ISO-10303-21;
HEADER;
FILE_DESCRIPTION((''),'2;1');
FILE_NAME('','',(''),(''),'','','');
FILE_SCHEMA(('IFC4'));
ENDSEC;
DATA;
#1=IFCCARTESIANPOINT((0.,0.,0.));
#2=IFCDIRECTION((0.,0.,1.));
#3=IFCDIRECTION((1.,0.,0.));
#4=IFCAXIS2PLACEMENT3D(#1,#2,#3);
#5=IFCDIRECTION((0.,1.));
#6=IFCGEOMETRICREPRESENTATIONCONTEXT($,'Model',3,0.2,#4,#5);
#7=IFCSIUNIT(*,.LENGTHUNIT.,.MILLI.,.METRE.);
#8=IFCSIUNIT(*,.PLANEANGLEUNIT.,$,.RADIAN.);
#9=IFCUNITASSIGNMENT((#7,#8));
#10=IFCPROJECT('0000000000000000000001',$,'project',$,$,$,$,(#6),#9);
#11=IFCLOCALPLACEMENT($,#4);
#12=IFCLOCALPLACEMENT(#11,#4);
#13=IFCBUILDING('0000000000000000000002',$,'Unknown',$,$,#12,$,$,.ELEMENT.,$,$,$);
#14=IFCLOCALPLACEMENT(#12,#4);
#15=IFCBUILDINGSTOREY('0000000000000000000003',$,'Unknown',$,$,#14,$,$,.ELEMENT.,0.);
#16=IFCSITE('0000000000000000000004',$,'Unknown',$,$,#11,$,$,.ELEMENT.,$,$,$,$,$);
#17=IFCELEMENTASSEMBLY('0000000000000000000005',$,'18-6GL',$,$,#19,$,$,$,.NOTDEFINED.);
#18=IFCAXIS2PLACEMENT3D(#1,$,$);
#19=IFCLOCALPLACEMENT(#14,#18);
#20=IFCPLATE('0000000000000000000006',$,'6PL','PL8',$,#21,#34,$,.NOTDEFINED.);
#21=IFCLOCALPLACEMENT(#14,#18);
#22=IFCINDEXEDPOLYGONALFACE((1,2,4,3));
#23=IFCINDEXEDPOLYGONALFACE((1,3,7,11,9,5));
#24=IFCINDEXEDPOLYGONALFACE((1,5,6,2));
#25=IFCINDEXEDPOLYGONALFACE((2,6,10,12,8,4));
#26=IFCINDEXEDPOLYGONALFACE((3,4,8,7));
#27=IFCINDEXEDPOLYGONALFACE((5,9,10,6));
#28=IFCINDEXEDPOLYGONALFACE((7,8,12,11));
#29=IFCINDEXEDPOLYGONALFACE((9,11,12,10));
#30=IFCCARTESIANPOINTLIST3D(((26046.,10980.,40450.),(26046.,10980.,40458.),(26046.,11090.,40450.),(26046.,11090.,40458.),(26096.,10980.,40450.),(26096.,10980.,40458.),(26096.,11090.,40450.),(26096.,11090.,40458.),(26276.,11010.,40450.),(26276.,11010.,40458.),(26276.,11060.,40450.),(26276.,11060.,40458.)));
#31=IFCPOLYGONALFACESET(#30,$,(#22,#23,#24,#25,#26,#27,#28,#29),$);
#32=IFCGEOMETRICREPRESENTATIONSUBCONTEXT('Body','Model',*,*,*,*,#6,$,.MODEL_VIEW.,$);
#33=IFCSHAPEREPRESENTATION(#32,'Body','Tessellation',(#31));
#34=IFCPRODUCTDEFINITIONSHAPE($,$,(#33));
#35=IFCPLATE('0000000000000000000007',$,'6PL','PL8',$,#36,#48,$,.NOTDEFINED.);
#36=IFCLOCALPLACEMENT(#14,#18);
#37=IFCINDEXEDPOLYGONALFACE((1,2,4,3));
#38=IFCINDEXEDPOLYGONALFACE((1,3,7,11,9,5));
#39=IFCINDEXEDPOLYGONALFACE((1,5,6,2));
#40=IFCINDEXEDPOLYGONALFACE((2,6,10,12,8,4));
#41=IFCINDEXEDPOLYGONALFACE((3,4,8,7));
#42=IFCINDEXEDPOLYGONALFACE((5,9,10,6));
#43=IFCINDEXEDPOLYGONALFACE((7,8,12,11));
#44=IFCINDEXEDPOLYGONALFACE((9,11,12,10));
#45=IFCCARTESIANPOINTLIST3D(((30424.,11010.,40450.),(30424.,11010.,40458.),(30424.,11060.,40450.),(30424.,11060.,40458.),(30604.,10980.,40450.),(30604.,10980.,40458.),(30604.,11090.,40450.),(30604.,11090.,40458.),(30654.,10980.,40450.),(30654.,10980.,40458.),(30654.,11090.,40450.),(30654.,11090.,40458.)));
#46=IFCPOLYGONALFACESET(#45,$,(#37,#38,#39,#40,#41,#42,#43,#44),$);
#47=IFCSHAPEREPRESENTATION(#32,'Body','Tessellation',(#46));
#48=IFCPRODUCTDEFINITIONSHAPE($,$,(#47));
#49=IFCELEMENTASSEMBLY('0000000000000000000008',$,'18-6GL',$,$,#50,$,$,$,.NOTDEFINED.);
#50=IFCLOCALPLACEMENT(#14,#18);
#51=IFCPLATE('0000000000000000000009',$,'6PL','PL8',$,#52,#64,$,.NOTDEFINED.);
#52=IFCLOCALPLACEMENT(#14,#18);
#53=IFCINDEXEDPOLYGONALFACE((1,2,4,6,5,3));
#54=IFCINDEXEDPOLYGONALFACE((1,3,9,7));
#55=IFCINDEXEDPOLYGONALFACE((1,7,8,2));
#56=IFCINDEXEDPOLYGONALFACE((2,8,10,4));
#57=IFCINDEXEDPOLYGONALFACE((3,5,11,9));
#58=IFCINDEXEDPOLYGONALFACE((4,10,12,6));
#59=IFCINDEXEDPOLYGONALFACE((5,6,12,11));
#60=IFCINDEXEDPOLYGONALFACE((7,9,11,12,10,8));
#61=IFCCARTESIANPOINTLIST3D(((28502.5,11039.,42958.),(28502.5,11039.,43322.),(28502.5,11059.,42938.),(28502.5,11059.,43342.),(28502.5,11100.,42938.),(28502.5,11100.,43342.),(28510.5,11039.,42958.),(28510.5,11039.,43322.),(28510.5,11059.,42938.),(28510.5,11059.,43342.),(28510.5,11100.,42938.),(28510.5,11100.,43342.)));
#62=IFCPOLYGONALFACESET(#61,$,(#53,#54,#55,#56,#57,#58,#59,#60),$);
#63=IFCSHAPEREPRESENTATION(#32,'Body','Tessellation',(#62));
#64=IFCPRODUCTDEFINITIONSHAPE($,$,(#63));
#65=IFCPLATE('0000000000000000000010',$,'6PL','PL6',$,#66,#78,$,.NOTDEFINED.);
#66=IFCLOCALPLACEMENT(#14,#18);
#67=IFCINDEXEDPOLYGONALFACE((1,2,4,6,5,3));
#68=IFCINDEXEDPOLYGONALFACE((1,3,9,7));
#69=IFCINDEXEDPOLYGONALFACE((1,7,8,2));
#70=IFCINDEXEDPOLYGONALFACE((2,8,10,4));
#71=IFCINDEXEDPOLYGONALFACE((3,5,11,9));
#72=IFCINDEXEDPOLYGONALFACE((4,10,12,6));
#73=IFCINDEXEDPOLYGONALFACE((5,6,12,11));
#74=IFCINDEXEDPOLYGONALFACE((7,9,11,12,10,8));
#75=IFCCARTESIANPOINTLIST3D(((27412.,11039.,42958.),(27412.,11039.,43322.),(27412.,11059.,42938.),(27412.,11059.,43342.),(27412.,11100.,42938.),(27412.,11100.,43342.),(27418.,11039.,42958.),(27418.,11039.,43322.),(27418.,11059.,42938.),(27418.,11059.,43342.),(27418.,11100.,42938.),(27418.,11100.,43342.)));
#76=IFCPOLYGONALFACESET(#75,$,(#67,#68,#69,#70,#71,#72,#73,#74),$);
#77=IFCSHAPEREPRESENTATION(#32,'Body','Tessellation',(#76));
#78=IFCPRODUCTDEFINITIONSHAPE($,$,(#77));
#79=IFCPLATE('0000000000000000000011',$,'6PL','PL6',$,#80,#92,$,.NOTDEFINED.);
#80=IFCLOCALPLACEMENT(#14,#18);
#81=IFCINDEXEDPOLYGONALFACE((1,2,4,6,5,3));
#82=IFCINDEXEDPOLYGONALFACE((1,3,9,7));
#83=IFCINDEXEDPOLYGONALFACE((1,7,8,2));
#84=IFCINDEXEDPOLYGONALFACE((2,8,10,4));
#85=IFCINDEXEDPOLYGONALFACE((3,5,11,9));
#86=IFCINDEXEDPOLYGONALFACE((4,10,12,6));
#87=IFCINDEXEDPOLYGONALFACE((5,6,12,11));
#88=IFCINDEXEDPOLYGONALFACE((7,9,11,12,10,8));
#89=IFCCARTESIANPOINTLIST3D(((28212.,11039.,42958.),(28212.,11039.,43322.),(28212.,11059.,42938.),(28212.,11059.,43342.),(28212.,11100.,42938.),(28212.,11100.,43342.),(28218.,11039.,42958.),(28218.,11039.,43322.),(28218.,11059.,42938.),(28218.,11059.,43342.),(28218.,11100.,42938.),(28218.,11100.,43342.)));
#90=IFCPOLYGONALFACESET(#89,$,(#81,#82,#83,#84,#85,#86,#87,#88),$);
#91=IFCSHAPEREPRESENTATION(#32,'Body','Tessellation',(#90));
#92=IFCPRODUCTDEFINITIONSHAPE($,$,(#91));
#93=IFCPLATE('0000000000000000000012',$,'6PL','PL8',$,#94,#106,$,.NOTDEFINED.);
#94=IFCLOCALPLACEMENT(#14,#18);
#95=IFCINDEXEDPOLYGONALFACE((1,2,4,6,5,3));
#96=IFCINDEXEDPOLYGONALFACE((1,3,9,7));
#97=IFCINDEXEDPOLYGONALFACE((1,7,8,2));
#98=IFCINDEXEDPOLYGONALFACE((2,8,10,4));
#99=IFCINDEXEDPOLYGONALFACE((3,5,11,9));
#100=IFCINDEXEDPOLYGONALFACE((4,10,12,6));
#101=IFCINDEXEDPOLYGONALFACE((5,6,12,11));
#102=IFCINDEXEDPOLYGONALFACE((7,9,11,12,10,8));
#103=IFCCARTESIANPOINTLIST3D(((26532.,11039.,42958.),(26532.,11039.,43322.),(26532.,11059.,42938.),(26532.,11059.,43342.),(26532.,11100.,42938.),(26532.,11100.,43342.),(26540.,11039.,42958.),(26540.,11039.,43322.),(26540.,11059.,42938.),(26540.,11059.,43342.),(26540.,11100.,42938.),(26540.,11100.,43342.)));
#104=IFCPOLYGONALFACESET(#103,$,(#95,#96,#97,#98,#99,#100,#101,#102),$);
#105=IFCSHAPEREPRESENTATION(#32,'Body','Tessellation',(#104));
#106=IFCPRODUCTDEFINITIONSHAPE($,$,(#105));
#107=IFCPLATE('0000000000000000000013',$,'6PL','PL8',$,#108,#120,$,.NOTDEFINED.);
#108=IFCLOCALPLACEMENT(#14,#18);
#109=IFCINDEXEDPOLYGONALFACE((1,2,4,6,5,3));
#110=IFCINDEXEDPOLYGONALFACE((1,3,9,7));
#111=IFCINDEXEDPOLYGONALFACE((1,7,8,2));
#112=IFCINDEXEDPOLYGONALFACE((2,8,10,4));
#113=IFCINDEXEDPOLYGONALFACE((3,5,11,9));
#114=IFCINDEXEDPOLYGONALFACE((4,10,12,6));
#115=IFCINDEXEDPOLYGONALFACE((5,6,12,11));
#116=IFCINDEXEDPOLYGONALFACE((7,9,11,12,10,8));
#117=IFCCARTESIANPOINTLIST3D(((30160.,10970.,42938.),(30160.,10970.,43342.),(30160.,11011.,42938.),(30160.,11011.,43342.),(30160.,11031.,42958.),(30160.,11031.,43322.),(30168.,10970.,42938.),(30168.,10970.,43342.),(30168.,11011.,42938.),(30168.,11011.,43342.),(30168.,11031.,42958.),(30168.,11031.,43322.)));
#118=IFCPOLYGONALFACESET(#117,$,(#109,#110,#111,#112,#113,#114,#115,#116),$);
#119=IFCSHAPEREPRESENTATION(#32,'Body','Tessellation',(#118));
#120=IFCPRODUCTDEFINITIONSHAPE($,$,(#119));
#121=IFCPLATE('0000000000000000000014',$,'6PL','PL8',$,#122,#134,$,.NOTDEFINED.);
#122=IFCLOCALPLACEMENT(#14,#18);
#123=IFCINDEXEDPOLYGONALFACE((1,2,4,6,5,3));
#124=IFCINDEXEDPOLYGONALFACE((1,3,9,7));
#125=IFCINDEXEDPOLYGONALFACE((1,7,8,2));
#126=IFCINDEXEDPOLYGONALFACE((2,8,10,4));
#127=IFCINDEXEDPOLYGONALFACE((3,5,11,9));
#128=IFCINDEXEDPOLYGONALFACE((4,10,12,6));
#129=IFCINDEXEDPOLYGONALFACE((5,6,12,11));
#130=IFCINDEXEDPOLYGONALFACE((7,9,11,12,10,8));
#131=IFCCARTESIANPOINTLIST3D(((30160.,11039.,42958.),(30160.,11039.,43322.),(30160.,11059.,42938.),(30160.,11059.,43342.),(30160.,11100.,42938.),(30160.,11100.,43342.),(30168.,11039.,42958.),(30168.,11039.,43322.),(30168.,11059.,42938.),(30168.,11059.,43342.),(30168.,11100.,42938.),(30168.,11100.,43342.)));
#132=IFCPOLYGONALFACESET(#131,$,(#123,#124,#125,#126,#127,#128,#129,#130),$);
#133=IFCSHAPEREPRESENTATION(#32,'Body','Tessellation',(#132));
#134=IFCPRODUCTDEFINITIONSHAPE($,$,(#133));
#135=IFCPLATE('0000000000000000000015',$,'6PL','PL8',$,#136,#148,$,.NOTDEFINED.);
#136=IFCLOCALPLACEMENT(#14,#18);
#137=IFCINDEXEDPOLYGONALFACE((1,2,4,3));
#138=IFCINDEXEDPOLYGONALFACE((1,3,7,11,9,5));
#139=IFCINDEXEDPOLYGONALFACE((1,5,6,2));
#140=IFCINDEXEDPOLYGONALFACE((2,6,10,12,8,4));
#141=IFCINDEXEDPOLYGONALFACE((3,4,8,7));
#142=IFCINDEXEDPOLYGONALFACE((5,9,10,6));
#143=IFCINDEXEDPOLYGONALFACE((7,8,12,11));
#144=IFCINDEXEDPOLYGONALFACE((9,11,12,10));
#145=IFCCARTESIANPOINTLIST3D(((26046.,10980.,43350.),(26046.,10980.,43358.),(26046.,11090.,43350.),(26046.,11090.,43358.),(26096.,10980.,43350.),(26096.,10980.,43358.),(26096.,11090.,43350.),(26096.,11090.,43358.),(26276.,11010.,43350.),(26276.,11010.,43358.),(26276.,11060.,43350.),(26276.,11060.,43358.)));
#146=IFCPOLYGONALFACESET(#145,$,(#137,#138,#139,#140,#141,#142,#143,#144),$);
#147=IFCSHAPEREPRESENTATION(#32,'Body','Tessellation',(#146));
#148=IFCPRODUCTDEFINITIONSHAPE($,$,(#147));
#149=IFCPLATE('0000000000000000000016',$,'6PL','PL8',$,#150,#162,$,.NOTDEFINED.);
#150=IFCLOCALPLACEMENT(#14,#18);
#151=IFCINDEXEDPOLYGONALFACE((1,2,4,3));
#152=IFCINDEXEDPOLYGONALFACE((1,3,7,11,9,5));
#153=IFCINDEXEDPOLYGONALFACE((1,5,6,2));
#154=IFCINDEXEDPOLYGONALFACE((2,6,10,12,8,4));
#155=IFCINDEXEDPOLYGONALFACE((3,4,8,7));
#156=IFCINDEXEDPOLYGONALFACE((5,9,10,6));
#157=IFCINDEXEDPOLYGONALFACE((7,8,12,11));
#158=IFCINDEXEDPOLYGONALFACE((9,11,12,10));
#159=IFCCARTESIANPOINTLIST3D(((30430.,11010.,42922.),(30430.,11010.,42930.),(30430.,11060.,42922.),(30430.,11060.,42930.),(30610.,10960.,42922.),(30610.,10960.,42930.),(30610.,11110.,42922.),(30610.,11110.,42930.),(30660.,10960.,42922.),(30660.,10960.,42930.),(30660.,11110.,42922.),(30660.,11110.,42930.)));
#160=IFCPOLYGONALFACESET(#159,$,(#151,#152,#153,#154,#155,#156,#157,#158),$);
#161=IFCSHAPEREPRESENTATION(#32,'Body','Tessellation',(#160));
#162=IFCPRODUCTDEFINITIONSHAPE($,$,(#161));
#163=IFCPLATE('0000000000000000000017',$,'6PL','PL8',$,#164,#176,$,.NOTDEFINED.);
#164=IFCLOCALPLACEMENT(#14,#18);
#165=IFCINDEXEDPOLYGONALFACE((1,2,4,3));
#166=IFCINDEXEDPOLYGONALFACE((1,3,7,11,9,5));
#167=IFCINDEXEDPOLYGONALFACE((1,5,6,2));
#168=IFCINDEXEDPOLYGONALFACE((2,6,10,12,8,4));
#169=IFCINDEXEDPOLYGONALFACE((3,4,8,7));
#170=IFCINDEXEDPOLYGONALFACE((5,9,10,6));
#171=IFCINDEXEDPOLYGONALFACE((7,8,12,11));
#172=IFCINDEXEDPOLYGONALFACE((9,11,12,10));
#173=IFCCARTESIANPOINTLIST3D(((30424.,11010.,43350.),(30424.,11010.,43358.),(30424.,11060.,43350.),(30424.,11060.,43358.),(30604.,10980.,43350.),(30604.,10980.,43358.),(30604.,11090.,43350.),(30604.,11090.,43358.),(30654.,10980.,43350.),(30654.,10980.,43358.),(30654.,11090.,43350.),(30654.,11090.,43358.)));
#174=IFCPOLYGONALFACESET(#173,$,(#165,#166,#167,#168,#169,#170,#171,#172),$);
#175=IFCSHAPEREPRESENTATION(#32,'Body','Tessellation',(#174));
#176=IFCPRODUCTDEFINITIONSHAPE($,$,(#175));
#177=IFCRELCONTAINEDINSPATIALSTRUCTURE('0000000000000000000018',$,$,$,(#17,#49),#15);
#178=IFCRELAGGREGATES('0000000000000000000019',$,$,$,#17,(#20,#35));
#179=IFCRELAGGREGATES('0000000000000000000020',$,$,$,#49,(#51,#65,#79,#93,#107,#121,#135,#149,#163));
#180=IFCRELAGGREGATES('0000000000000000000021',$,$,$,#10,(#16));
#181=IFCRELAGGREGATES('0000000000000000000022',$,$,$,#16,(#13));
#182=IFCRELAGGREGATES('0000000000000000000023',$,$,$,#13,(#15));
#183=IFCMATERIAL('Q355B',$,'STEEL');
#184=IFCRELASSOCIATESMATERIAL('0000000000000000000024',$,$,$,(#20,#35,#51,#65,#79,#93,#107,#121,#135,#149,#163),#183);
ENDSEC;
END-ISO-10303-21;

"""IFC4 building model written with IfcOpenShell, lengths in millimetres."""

from ifc_helpers import new_model, si_unit, direction, frame, origin_with_axes, place, context, subcontext, project, spatial, line, indexed_curve, outline, extrude, material, element, aggregate, save


model = new_model("IFC4")

# Units and contexts
model_context = context("Model", 3, precision=0.2, world=origin_with_axes(), true_north=direction((0.0, 1.0)))
body_context = subcontext(model_context, "Body", "Model", "MODEL_VIEW")
ifc_project = project(units=[si_unit("LENGTHUNIT", "METRE", prefix="MILLI"), si_unit("PLANEANGLEUNIT", "RADIAN")], contexts=[model_context])

# Site, building, storey
site_placement = place(None, origin_with_axes())
site = spatial("IfcSite", under=ifc_project, at=site_placement, Name="Unknown", CompositionType="ELEMENT")
building_placement = place(site_placement, origin_with_axes())
building = spatial("IfcBuilding", under=site, at=building_placement, Name="Unknown", CompositionType="ELEMENT")
storey_placement = place(building_placement, origin_with_axes())
storey = spatial("IfcBuildingStorey", under=building, at=storey_placement, Name="Unknown", CompositionType="ELEMENT", Elevation=0.0)

# Shared definitions
ifc_material = material(Name="Q355B", Category="STEEL")

# Element assemblies, plates
assembly_1_placement = place(storey_placement, frame((26000.0, 11035.0, 40240.0), z_axis=(0.0, -1.0, 0.0), x_axis=(1.0, 0.0, 0.0)))
assembly_1 = element("IfcElementAssembly", 1, at=assembly_1_placement, inside=storey, Name="18-6GL", PredefinedType="NOTDEFINED")
plate_1_placement = place(assembly_1_placement, frame((96.0, 214.0, -55.0), z_axis=(0.0, 1.0, 0.0), x_axis=(-1.0, 0.0, 0.0)))
plate_1 = element("IfcPlate", 2, at=plate_1_placement, material=ifc_material, Name="6PL", Description="PL8", PredefinedType="NOTDEFINED", context=body_context, shape_type="SolidModel", body=[
    extrude(outline(indexed_curve([(0.0, 0.0), (50.0, 0.0), (50.0, 110.0), (0.0, 110.0), (-180.0, 80.0), (-180.0, 30.0)], segments=[line(1, 2, 3, 4, 5, 6, 1)])), frame((0.0, 0.0, 4.0), z_axis=(0.0, 0.0, 1.0), x_axis=(1.0, 0.0, 0.0)), (0.0, 0.0, -1.0), 8.0),
])
plate_2_placement = place(assembly_1_placement, frame((4604.0, 214.0, 55.0), z_axis=(0.0, 1.0, 0.0), x_axis=(1.0, 0.0, 0.0)))
plate_2 = element("IfcPlate", 3, at=plate_2_placement, material=ifc_material, Name="6PL", Description="PL8", PredefinedType="NOTDEFINED", context=body_context, shape_type="SolidModel", body=[
    extrude(outline(indexed_curve([(0.0, 0.0), (50.0, 0.0), (50.0, 110.0), (0.0, 110.0), (-180.0, 80.0), (-180.0, 30.0)], segments=[line(1, 2, 3, 4, 5, 6, 1)])), frame((0.0, 0.0, 4.0), z_axis=(0.0, 0.0, 1.0), x_axis=(1.0, 0.0, 0.0)), (0.0, 0.0, -1.0), 8.0),
])
aggregate(assembly_1, [plate_1, plate_2])
assembly_2_placement = place(storey_placement, frame((26000.0, 11035.0, 43140.0), z_axis=(0.0, -1.0, 0.0), x_axis=(1.0, 0.0, 0.0)))
assembly_2 = element("IfcElementAssembly", 4, at=assembly_2_placement, inside=storey, Name="18-6GL", PredefinedType="NOTDEFINED")
plate_3_placement = place(assembly_2_placement, frame((2506.5, -202.0, -4.0), z_axis=(1.0, 0.0, 0.0), x_axis=(0.0, 0.0, -1.0)))
plate_3 = element("IfcPlate", 5, at=plate_3_placement, material=ifc_material, Name="6PL", Description="PL8", PredefinedType="NOTDEFINED", context=body_context, shape_type="SolidModel", body=[
    extrude(outline(indexed_curve([(0.0, 20.0), (20.0, 0.0), (61.0, 0.0), (61.0, 404.0), (20.0, 404.0), (0.0, 384.0)], segments=[line(1, 2, 3, 4, 5, 6, 1)])), frame((0.0, 0.0, 4.0), z_axis=(0.0, 0.0, 1.0), x_axis=(1.0, 0.0, 0.0)), (0.0, 0.0, -1.0), 8.0),
])
plate_4_placement = place(assembly_2_placement, frame((1415.0, -202.0, -4.0), z_axis=(1.0, 0.0, 0.0), x_axis=(0.0, 0.0, -1.0)))
plate_4 = element("IfcPlate", 6, at=plate_4_placement, material=ifc_material, Name="6PL", Description="PL6", PredefinedType="NOTDEFINED", context=body_context, shape_type="SolidModel", body=[
    extrude(outline(indexed_curve([(0.0, 20.0), (20.0, 0.0), (61.0, 0.0), (61.0, 404.0), (20.0, 404.0), (0.0, 384.0)], segments=[line(1, 2, 3, 4, 5, 6, 1)])), frame((0.0, 0.0, 3.0), z_axis=(0.0, 0.0, 1.0), x_axis=(1.0, 0.0, 0.0)), (0.0, 0.0, -1.0), 6.0),
])
plate_5_placement = place(assembly_2_placement, frame((2215.0, -202.0, -4.0), z_axis=(1.0, 0.0, 0.0), x_axis=(0.0, 0.0, -1.0)))
plate_5 = element("IfcPlate", 7, at=plate_5_placement, material=ifc_material, Name="6PL", Description="PL6", PredefinedType="NOTDEFINED", context=body_context, shape_type="SolidModel", body=[
    extrude(outline(indexed_curve([(0.0, 20.0), (20.0, 0.0), (61.0, 0.0), (61.0, 404.0), (20.0, 404.0), (0.0, 384.0)], segments=[line(1, 2, 3, 4, 5, 6, 1)])), frame((0.0, 0.0, 3.0), z_axis=(0.0, 0.0, 1.0), x_axis=(1.0, 0.0, 0.0)), (0.0, 0.0, -1.0), 6.0),
])
plate_6_placement = place(assembly_2_placement, frame((536.0, -202.0, -4.0), z_axis=(1.0, 0.0, 0.0), x_axis=(0.0, 0.0, -1.0)))
plate_6 = element("IfcPlate", 8, at=plate_6_placement, material=ifc_material, Name="6PL", Description="PL8", PredefinedType="NOTDEFINED", context=body_context, shape_type="SolidModel", body=[
    extrude(outline(indexed_curve([(0.0, 20.0), (20.0, 0.0), (61.0, 0.0), (61.0, 404.0), (20.0, 404.0), (0.0, 384.0)], segments=[line(1, 2, 3, 4, 5, 6, 1)])), frame((0.0, 0.0, 4.0), z_axis=(0.0, 0.0, 1.0), x_axis=(1.0, 0.0, 0.0)), (0.0, 0.0, -1.0), 8.0),
])
plate_7_placement = place(assembly_2_placement, frame((4164.0, -202.0, 65.0), z_axis=(1.0, 0.0, 0.0), x_axis=(0.0, 0.0, -1.0)))
plate_7 = element("IfcPlate", 9, at=plate_7_placement, material=ifc_material, Name="6PL", Description="PL8", PredefinedType="NOTDEFINED", context=body_context, shape_type="SolidModel", body=[
    extrude(outline(indexed_curve([(0.0, 0.0), (41.0, 0.0), (61.0, 20.0), (61.0, 384.0), (41.0, 404.0), (0.0, 404.0)], segments=[line(1, 2, 3, 4, 5, 6, 1)])), frame((0.0, 0.0, 4.0), z_axis=(0.0, 0.0, 1.0), x_axis=(1.0, 0.0, 0.0)), (0.0, 0.0, -1.0), 8.0),
])
plate_8_placement = place(assembly_2_placement, frame((4164.0, -202.0, -4.0), z_axis=(1.0, 0.0, 0.0), x_axis=(0.0, 0.0, -1.0)))
plate_8 = element("IfcPlate", 10, at=plate_8_placement, material=ifc_material, Name="6PL", Description="PL8", PredefinedType="NOTDEFINED", context=body_context, shape_type="SolidModel", body=[
    extrude(outline(indexed_curve([(0.0, 20.0), (20.0, 0.0), (61.0, 0.0), (61.0, 404.0), (20.0, 404.0), (0.0, 384.0)], segments=[line(1, 2, 3, 4, 5, 6, 1)])), frame((0.0, 0.0, 4.0), z_axis=(0.0, 0.0, 1.0), x_axis=(1.0, 0.0, 0.0)), (0.0, 0.0, -1.0), 8.0),
])
plate_9_placement = place(assembly_2_placement, frame((96.0, 214.0, -55.0), z_axis=(0.0, 1.0, 0.0), x_axis=(-1.0, 0.0, 0.0)))
plate_9 = element("IfcPlate", 11, at=plate_9_placement, material=ifc_material, Name="6PL", Description="PL8", PredefinedType="NOTDEFINED", context=body_context, shape_type="SolidModel", body=[
    extrude(outline(indexed_curve([(0.0, 0.0), (50.0, 0.0), (50.0, 110.0), (0.0, 110.0), (-180.0, 80.0), (-180.0, 30.0)], segments=[line(1, 2, 3, 4, 5, 6, 1)])), frame((0.0, 0.0, 4.0), z_axis=(0.0, 0.0, 1.0), x_axis=(1.0, 0.0, 0.0)), (0.0, 0.0, -1.0), 8.0),
])
plate_10_placement = place(assembly_2_placement, frame((4610.0, -214.0, 75.0), z_axis=(0.0, 1.0, 0.0), x_axis=(1.0, 0.0, 0.0)))
plate_10 = element("IfcPlate", 12, at=plate_10_placement, material=ifc_material, Name="6PL", Description="PL8", PredefinedType="NOTDEFINED", context=body_context, shape_type="SolidModel", body=[
    extrude(outline(indexed_curve([(0.0, 0.0), (50.0, 0.0), (50.0, 150.0), (0.0, 150.0), (-180.0, 100.0), (-180.0, 50.0)], segments=[line(1, 2, 3, 4, 5, 6, 1)])), frame((0.0, 0.0, 4.0), z_axis=(0.0, 0.0, 1.0), x_axis=(1.0, 0.0, 0.0)), (0.0, 0.0, -1.0), 8.0),
])
plate_11_placement = place(assembly_2_placement, frame((4604.0, 214.0, 55.0), z_axis=(0.0, 1.0, 0.0), x_axis=(1.0, 0.0, 0.0)))
plate_11 = element("IfcPlate", 13, at=plate_11_placement, material=ifc_material, Name="6PL", Description="PL8", PredefinedType="NOTDEFINED", context=body_context, shape_type="SolidModel", body=[
    extrude(outline(indexed_curve([(0.0, 0.0), (50.0, 0.0), (50.0, 110.0), (0.0, 110.0), (-180.0, 80.0), (-180.0, 30.0)], segments=[line(1, 2, 3, 4, 5, 6, 1)])), frame((0.0, 0.0, 4.0), z_axis=(0.0, 0.0, 1.0), x_axis=(1.0, 0.0, 0.0)), (0.0, 0.0, -1.0), 8.0),
])
aggregate(assembly_2, [plate_3, plate_4, plate_5, plate_6, plate_7, plate_8, plate_9, plate_10, plate_11])

save(model, "model.ifc")
